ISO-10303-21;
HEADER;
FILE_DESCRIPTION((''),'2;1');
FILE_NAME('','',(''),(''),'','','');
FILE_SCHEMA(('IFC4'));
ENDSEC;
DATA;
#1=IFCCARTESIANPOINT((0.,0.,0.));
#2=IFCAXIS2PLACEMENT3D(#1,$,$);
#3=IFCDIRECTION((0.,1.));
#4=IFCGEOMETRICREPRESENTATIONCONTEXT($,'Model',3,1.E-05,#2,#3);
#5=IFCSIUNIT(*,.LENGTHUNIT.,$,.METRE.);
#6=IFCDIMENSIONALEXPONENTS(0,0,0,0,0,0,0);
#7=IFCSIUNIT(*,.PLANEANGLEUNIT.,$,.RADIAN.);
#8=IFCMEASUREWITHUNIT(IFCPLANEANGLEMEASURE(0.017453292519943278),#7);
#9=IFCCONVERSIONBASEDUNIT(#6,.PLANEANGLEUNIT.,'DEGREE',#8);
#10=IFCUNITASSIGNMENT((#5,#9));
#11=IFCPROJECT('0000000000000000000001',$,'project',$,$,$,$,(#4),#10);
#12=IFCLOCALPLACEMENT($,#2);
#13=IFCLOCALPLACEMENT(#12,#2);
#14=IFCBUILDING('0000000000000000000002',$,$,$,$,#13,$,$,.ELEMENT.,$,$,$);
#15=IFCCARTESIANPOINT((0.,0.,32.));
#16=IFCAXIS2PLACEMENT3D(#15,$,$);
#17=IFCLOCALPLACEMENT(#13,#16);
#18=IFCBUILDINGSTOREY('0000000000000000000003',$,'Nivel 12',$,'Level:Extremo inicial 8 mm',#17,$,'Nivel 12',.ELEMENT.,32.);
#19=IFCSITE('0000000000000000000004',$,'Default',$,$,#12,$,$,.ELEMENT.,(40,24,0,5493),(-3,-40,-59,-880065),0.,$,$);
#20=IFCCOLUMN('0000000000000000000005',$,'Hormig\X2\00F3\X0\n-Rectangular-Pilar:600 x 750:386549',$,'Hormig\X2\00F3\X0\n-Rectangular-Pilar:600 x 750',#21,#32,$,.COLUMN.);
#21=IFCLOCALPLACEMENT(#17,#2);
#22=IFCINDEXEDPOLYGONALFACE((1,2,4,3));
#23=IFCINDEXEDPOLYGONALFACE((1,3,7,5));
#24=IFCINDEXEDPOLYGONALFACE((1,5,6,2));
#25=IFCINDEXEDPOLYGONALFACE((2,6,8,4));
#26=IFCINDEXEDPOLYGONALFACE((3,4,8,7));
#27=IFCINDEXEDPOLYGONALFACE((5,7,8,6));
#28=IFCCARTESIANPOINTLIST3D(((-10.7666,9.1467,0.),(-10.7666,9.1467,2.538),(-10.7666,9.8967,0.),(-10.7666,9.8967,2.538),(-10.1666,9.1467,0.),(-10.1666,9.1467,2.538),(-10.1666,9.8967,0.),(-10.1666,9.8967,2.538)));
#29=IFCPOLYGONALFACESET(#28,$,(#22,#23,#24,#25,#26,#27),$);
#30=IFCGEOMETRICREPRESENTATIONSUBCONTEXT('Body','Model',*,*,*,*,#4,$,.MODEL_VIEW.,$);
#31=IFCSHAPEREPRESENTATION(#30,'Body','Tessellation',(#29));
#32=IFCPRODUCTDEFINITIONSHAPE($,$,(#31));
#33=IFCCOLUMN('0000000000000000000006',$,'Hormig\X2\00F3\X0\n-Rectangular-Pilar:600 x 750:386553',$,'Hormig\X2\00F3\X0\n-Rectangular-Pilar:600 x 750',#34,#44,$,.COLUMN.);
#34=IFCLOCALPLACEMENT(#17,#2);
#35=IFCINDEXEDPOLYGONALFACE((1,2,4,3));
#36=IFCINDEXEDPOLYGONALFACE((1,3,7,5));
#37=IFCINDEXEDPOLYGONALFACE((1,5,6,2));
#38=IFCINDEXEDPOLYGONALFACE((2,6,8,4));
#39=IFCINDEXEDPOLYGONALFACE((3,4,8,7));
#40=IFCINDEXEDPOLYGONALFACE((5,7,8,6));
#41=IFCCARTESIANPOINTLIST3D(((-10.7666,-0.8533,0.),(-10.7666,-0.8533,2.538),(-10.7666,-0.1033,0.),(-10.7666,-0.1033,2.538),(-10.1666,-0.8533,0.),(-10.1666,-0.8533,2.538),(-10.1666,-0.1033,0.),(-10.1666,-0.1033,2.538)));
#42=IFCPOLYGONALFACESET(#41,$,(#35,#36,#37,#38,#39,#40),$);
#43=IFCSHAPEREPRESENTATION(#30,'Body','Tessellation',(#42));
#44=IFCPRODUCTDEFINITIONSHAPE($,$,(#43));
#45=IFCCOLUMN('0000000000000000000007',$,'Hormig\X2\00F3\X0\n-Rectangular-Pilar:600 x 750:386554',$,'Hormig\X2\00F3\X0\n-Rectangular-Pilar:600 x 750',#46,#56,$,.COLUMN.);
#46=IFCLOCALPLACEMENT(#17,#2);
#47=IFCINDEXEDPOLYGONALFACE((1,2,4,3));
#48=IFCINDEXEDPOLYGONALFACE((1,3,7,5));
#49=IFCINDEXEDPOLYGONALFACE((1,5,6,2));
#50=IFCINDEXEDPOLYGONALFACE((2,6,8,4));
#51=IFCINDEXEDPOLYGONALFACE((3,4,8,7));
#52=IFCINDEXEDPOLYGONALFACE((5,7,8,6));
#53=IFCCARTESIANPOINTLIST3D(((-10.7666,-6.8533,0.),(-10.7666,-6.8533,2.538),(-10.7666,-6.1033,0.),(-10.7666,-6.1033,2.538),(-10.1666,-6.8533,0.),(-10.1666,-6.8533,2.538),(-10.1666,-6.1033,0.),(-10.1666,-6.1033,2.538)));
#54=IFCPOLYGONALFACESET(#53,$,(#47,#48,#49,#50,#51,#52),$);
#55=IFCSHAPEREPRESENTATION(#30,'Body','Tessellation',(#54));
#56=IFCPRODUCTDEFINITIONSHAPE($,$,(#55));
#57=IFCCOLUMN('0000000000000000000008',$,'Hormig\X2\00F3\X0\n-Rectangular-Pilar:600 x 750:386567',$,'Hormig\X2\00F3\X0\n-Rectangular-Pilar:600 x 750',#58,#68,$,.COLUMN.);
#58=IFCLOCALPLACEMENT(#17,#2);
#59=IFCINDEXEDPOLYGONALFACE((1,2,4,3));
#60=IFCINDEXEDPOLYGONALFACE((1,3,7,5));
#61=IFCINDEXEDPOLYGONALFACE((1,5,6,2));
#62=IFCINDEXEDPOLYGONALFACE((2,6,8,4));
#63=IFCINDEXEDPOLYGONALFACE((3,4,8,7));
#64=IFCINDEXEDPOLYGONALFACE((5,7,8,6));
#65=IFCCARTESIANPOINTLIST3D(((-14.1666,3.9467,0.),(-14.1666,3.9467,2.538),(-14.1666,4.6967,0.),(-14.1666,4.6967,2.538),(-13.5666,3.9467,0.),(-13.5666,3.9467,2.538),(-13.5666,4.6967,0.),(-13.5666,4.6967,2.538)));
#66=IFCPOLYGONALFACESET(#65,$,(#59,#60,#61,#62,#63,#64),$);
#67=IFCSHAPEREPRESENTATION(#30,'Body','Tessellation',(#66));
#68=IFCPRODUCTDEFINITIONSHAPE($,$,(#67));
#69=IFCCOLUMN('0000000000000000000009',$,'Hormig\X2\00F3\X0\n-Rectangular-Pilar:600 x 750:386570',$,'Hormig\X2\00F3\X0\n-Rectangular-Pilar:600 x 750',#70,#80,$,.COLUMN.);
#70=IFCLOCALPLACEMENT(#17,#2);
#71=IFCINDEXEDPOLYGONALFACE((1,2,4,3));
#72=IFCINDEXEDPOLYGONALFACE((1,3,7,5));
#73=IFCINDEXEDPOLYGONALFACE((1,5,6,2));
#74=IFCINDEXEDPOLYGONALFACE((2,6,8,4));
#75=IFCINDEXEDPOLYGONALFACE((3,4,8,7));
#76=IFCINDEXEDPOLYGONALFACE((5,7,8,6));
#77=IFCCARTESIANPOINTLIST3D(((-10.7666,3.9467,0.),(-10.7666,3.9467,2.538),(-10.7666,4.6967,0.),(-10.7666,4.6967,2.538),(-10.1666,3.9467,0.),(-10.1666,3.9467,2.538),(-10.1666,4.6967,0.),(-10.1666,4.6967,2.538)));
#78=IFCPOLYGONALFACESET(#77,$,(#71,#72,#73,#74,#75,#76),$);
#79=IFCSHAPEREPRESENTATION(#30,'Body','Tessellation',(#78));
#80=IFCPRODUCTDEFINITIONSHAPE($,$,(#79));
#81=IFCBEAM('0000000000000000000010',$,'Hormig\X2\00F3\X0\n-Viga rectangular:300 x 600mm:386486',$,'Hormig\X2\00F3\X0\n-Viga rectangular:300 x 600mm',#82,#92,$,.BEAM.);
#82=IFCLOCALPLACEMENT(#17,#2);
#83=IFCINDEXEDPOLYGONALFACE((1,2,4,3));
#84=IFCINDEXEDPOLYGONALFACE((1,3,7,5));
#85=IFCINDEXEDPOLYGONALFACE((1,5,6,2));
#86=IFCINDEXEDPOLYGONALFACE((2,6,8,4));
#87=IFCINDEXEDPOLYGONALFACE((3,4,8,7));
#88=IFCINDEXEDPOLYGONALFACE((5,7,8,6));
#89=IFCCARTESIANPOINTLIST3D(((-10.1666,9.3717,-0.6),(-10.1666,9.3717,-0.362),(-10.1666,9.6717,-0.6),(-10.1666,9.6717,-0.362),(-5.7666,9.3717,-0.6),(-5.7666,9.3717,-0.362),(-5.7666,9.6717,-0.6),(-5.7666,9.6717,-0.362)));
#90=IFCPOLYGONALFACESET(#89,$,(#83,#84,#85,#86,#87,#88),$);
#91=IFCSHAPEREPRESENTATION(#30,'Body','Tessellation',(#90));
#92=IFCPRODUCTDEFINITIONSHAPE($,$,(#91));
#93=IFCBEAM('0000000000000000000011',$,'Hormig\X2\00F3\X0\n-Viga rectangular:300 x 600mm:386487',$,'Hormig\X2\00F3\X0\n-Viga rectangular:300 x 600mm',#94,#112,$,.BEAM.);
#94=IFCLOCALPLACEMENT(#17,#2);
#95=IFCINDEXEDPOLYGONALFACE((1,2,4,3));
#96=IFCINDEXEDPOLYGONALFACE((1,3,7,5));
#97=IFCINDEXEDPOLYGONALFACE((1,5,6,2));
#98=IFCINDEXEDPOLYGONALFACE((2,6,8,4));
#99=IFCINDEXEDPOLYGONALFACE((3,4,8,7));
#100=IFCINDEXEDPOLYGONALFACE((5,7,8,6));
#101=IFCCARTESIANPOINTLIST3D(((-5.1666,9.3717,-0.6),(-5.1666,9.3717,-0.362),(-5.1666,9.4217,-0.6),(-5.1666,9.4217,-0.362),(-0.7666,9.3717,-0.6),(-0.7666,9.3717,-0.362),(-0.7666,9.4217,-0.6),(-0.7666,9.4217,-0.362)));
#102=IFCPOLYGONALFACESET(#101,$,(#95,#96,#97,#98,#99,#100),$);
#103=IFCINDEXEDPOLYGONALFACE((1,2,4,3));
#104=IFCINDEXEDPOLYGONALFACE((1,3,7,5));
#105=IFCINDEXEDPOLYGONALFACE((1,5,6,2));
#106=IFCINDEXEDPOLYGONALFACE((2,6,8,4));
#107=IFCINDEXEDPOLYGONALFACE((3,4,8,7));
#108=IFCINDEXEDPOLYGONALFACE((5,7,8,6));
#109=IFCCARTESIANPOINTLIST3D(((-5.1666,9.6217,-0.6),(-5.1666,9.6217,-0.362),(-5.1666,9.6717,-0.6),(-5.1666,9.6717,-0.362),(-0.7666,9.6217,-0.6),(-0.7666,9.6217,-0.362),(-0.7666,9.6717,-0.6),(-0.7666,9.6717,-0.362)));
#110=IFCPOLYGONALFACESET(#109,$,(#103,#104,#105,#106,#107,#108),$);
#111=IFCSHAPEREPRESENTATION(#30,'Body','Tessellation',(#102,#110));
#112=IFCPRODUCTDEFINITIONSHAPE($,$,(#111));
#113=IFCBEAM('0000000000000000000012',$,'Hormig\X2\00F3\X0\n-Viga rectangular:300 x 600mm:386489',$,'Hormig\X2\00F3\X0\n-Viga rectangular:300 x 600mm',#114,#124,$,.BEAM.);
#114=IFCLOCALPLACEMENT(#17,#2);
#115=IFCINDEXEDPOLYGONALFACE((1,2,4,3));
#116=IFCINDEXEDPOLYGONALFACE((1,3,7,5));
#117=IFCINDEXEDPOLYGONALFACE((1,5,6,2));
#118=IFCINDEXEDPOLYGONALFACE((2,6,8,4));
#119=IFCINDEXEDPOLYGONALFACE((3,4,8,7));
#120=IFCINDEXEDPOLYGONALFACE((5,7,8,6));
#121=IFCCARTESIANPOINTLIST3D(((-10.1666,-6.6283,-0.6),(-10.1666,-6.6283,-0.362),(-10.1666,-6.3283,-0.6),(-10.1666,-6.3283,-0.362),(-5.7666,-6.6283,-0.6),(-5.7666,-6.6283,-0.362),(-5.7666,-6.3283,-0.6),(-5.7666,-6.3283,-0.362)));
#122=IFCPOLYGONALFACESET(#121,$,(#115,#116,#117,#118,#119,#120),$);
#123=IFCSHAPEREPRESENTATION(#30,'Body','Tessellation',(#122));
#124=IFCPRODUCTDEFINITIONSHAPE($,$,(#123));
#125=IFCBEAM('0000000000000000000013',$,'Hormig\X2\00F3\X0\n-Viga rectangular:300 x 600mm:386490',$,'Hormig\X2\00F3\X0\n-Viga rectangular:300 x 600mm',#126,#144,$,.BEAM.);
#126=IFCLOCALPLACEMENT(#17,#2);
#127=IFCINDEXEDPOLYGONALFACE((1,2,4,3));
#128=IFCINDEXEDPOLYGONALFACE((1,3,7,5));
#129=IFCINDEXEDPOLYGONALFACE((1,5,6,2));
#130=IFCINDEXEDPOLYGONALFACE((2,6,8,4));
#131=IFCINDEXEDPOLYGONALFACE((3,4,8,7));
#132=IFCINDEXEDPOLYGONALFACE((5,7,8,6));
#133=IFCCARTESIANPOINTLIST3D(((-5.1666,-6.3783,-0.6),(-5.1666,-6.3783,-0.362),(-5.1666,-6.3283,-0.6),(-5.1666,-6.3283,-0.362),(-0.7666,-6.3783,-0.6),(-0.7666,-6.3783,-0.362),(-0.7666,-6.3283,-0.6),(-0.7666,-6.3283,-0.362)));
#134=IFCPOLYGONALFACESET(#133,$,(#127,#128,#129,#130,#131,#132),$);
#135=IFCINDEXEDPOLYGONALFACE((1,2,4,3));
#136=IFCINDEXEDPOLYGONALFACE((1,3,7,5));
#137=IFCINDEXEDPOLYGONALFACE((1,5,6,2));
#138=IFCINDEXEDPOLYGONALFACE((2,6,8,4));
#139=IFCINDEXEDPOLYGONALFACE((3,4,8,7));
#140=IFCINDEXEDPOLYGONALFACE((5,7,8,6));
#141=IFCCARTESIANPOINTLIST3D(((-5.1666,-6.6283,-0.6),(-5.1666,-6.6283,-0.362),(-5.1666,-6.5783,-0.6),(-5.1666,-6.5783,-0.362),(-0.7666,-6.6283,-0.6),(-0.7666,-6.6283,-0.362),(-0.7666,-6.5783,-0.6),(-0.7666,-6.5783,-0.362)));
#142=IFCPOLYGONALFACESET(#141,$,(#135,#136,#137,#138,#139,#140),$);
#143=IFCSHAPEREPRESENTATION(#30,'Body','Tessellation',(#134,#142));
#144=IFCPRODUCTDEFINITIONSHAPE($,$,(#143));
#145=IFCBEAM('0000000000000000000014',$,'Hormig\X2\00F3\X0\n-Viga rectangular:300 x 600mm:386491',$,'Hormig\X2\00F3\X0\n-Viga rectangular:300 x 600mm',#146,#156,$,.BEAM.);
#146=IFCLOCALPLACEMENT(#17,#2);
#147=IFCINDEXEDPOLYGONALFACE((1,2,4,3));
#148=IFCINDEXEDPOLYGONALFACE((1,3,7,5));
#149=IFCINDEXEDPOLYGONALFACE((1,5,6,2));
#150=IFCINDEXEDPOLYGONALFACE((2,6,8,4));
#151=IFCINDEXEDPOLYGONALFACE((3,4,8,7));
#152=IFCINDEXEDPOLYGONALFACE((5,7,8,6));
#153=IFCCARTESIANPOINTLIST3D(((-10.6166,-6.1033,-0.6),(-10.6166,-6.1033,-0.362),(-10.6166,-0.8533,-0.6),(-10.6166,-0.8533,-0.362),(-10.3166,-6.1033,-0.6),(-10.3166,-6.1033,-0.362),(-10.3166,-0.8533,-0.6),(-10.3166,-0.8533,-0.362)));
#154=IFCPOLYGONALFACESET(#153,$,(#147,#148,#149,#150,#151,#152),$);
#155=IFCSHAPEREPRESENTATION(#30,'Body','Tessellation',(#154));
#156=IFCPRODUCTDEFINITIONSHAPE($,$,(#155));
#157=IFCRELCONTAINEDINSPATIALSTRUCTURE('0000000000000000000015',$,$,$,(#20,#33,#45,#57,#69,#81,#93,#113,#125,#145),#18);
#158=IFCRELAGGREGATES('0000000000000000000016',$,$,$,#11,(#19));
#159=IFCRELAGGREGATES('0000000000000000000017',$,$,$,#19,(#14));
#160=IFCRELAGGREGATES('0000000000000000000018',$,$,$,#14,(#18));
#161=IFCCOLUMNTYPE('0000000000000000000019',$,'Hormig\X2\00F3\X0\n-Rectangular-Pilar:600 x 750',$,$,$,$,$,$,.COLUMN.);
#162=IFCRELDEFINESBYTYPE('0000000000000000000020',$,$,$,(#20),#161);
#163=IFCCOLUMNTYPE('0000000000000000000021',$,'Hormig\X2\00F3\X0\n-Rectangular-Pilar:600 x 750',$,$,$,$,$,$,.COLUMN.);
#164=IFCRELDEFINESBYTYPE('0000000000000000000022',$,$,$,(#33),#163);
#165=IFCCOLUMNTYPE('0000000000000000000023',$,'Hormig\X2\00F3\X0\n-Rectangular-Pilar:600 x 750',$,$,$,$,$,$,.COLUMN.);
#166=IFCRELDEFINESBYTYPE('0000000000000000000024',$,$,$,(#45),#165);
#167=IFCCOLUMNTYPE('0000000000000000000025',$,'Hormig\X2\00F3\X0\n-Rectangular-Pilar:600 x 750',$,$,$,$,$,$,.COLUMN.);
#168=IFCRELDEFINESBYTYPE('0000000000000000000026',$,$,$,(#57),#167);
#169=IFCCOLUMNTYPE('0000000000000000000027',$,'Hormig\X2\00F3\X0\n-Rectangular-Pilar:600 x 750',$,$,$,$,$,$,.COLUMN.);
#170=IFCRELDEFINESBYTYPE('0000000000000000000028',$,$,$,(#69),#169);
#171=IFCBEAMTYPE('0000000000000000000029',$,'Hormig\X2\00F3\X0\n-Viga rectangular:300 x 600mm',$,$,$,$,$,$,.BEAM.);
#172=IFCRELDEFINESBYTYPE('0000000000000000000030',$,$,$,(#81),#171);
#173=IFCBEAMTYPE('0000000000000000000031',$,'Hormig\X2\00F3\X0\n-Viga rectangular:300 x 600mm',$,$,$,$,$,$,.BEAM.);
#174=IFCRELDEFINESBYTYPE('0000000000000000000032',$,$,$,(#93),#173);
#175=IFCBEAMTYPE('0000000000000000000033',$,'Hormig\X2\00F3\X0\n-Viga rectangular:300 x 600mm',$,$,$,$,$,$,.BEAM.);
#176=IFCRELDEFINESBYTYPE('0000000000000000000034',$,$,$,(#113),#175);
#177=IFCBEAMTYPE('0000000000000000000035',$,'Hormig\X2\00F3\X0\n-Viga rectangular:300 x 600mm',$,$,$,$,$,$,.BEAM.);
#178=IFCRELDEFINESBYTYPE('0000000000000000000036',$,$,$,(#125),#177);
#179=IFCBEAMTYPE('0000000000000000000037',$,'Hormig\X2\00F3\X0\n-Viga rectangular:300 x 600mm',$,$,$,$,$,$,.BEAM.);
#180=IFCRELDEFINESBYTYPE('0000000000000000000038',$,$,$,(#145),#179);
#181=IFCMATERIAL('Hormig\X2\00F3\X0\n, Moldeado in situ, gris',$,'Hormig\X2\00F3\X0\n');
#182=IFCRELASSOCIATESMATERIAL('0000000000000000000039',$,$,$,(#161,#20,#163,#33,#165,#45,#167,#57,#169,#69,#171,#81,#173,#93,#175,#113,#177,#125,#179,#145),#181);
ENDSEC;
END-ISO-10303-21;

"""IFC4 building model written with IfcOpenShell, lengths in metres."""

from ifc_helpers import new_model, entity, si_unit, converted_unit, direction, frame, origin, place, context, subcontext, project, spatial, indexed_curve, outline, extrude, source, transform, mapped, material, type_object, type_shapes, element, save


model = new_model("IFC4")

# Units and contexts
model_context = context("Model", 3, precision=1e-05, world=origin(), true_north=direction((0.0, 1.0)))
body_context = subcontext(model_context, "Body", "Model", "MODEL_VIEW")
ifc_project = project(units=[si_unit("LENGTHUNIT", "METRE"), converted_unit("PLANEANGLEUNIT", "DEGREE", entity("IfcPlaneAngleMeasure", 0.017453292519943278), si_unit("PLANEANGLEUNIT", "RADIAN"), dimensions=[0, 0, 0, 0, 0, 0, 0])], contexts=[model_context])

# Site, building, storey
site_placement = place(None, origin())
site = spatial("IfcSite", under=ifc_project, at=site_placement, Name="Default", CompositionType="ELEMENT", RefLatitude=(40, 24, 0, 5493), RefLongitude=(-3, -40, -59, -880065), RefElevation=0.0)
building_placement = place(site_placement, origin())
building = spatial("IfcBuilding", under=site, at=building_placement, CompositionType="ELEMENT")
storey_placement = place(building_placement, frame((0.0, 0.0, 32.0)))
storey = spatial("IfcBuildingStorey", under=building, at=storey_placement, Name="Nivel 12", ObjectType="Level:Extremo inicial 8 mm", LongName="Nivel 12", CompositionType="ELEMENT", Elevation=32.0)

# Columns
ifc_material_1 = material(Name="Hormigón, Moldeado in situ, gris", Category="Hormigón")
column_type_1 = type_object("IfcColumnType", Name="Hormigón-Rectangular-Pilar:600 x 750", PredefinedType="COLUMN", material=ifc_material_1)
shared_shape_1 = source(origin(), body_context, "Body", "SweptSolid", [
    extrude(outline(indexed_curve([(-0.3, -0.375), (0.3, -0.375), (0.3, 0.375), (-0.3, 0.375), (-0.3, -0.375)], self_intersect=False)), frame((-10.4666, 9.5217, 32.0), z_axis=(0.0, 0.0, 1.0), x_axis=(-1.0, 0.0, 0.0)), (0.0, 0.0, 1.0), 2.538),
])
type_shapes(column_type_1, [shared_shape_1])
column_1_placement = place(storey_placement, frame((0.0, 0.0, -32.0)))
element("IfcColumn", 1, at=column_1_placement, inside=storey, type_object=column_type_1, material=ifc_material_1, Name="Hormigón-Rectangular-Pilar:600 x 750:386549", ObjectType="Hormigón-Rectangular-Pilar:600 x 750", PredefinedType="COLUMN", context=body_context, shape_type="MappedRepresentation", body=[
    mapped(shared_shape_1, transform((0.0, 0.0, 0.0), scale=1.0)),
])
column_type_2 = type_object("IfcColumnType", Name="Hormigón-Rectangular-Pilar:600 x 750", PredefinedType="COLUMN", material=ifc_material_1)
shared_shape_2 = source(origin(), body_context, "Body", "SweptSolid", [
    extrude(outline(indexed_curve([(-0.3, -0.375), (0.3, -0.375), (0.3, 0.375), (-0.3, 0.375), (-0.3, -0.375)], self_intersect=False)), frame((-10.4666, -0.4783, 32.0), z_axis=(0.0, 0.0, 1.0), x_axis=(-1.0, 0.0, 0.0)), (0.0, 0.0, 1.0), 2.538),
])
type_shapes(column_type_2, [shared_shape_2])
column_2_placement = place(storey_placement, frame((0.0, 0.0, -32.0)))
element("IfcColumn", 2, at=column_2_placement, inside=storey, type_object=column_type_2, material=ifc_material_1, Name="Hormigón-Rectangular-Pilar:600 x 750:386553", ObjectType="Hormigón-Rectangular-Pilar:600 x 750", PredefinedType="COLUMN", context=body_context, shape_type="MappedRepresentation", body=[
    mapped(shared_shape_2, transform((0.0, 0.0, 0.0), scale=1.0)),
])
column_type_3 = type_object("IfcColumnType", Name="Hormigón-Rectangular-Pilar:600 x 750", PredefinedType="COLUMN", material=ifc_material_1)
shared_shape_3 = source(origin(), body_context, "Body", "SweptSolid", [
    extrude(outline(indexed_curve([(-0.3, -0.375), (0.3, -0.375), (0.3, 0.375), (-0.3, 0.375), (-0.3, -0.375)], self_intersect=False)), frame((-10.4666, -6.4783, 32.0), z_axis=(0.0, 0.0, 1.0), x_axis=(-1.0, 0.0, 0.0)), (0.0, 0.0, 1.0), 2.538),
])
type_shapes(column_type_3, [shared_shape_3])
column_3_placement = place(storey_placement, frame((0.0, 0.0, -32.0)))
element("IfcColumn", 3, at=column_3_placement, inside=storey, type_object=column_type_3, material=ifc_material_1, Name="Hormigón-Rectangular-Pilar:600 x 750:386554", ObjectType="Hormigón-Rectangular-Pilar:600 x 750", PredefinedType="COLUMN", context=body_context, shape_type="MappedRepresentation", body=[
    mapped(shared_shape_3, transform((0.0, 0.0, 0.0), scale=1.0)),
])
column_type_4 = type_object("IfcColumnType", Name="Hormigón-Rectangular-Pilar:600 x 750", PredefinedType="COLUMN", material=ifc_material_1)
shared_shape_4 = source(origin(), body_context, "Body", "SweptSolid", [
    extrude(outline(indexed_curve([(-0.3, -0.375), (0.3, -0.375), (0.3, 0.375), (-0.3, 0.375), (-0.3, -0.375)], self_intersect=False)), frame((-13.8666, 4.3217, 32.0), z_axis=(0.0, 0.0, 1.0), x_axis=(-1.0, 0.0, 0.0)), (0.0, 0.0, 1.0), 2.538),
])
type_shapes(column_type_4, [shared_shape_4])
column_4_placement = place(storey_placement, frame((0.0, 0.0, -32.0)))
element("IfcColumn", 4, at=column_4_placement, inside=storey, type_object=column_type_4, material=ifc_material_1, Name="Hormigón-Rectangular-Pilar:600 x 750:386567", ObjectType="Hormigón-Rectangular-Pilar:600 x 750", PredefinedType="COLUMN", context=body_context, shape_type="MappedRepresentation", body=[
    mapped(shared_shape_4, transform((0.0, 0.0, 0.0), scale=1.0)),
])
column_type_5 = type_object("IfcColumnType", Name="Hormigón-Rectangular-Pilar:600 x 750", PredefinedType="COLUMN", material=ifc_material_1)
shared_shape_5 = source(origin(), body_context, "Body", "SweptSolid", [
    extrude(outline(indexed_curve([(-0.3, -0.375), (0.3, -0.375), (0.3, 0.375), (-0.3, 0.375), (-0.3, -0.375)], self_intersect=False)), frame((-10.4666, 4.3217, 32.0), z_axis=(0.0, 0.0, 1.0), x_axis=(-1.0, 0.0, 0.0)), (0.0, 0.0, 1.0), 2.538),
])
type_shapes(column_type_5, [shared_shape_5])
column_5_placement = place(storey_placement, frame((0.0, 0.0, -32.0)))
element("IfcColumn", 5, at=column_5_placement, inside=storey, type_object=column_type_5, material=ifc_material_1, Name="Hormigón-Rectangular-Pilar:600 x 750:386570", ObjectType="Hormigón-Rectangular-Pilar:600 x 750", PredefinedType="COLUMN", context=body_context, shape_type="MappedRepresentation", body=[
    mapped(shared_shape_5, transform((0.0, 0.0, 0.0), scale=1.0)),
])

# Beams
beam_type_1 = type_object("IfcBeamType", Name="Hormigón-Viga rectangular:300 x 600mm", PredefinedType="BEAM", material=ifc_material_1)
shared_shape_6 = source(origin(), body_context, "Body", "SweptSolid", [
    extrude(outline(indexed_curve([(-0.119, -0.15), (0.119, -0.15), (0.119, 0.15), (-0.119, 0.15), (-0.119, -0.15)], self_intersect=False)), frame((-5.7666, 9.5217, 31.519), z_axis=(-1.0, 0.0, 0.0), x_axis=(0.0, 0.0, -1.0)), (0.0, 0.0, 1.0), 4.4),
])
type_shapes(beam_type_1, [shared_shape_6])
beam_1_placement = place(storey_placement, frame((0.0, 0.0, -32.0)))
element("IfcBeam", 6, at=beam_1_placement, inside=storey, type_object=beam_type_1, material=ifc_material_1, Name="Hormigón-Viga rectangular:300 x 600mm:386486", ObjectType="Hormigón-Viga rectangular:300 x 600mm", PredefinedType="BEAM", context=body_context, shape_type="MappedRepresentation", body=[
    mapped(shared_shape_6, transform((0.0, 0.0, 0.0), scale=1.0)),
])
beam_type_2 = type_object("IfcBeamType", Name="Hormigón-Viga rectangular:300 x 600mm", PredefinedType="BEAM", material=ifc_material_1)
shared_shape_7 = source(origin(), body_context, "Body", "SweptSolid", [
    extrude(outline(indexed_curve([(-0.119, -0.025), (0.119, -0.025), (0.119, 0.025), (-0.119, 0.025), (-0.119, -0.025)], self_intersect=False)), frame((-5.1666, 9.3967, 31.519), z_axis=(1.0, 0.0, 0.0), x_axis=(0.0, 0.0, -1.0)), (0.0, 0.0, 1.0), 4.4),
    extrude(outline(indexed_curve([(-0.119, -0.025), (0.119, -0.025), (0.119, 0.025), (-0.119, 0.025), (-0.119, -0.025)], self_intersect=False)), frame((-5.1666, 9.6467, 31.519), z_axis=(1.0, 0.0, 0.0), x_axis=(0.0, 0.0, -1.0)), (0.0, 0.0, 1.0), 4.4),
])
type_shapes(beam_type_2, [shared_shape_7])
beam_2_placement = place(storey_placement, frame((0.0, 0.0, -32.0)))
element("IfcBeam", 7, at=beam_2_placement, inside=storey, type_object=beam_type_2, material=ifc_material_1, Name="Hormigón-Viga rectangular:300 x 600mm:386487", ObjectType="Hormigón-Viga rectangular:300 x 600mm", PredefinedType="BEAM", context=body_context, shape_type="MappedRepresentation", body=[
    mapped(shared_shape_7, transform((0.0, 0.0, 0.0), scale=1.0)),
])
beam_type_3 = type_object("IfcBeamType", Name="Hormigón-Viga rectangular:300 x 600mm", PredefinedType="BEAM", material=ifc_material_1)
shared_shape_8 = source(origin(), body_context, "Body", "SweptSolid", [
    extrude(outline(indexed_curve([(-0.119, -0.15), (0.119, -0.15), (0.119, 0.15), (-0.119, 0.15), (-0.119, -0.15)], self_intersect=False)), frame((-10.1666, -6.4783, 31.519), z_axis=(1.0, 0.0, 0.0), x_axis=(0.0, 0.0, -1.0)), (0.0, 0.0, 1.0), 4.4),
])
type_shapes(beam_type_3, [shared_shape_8])
beam_3_placement = place(storey_placement, frame((0.0, 0.0, -32.0)))
element("IfcBeam", 8, at=beam_3_placement, inside=storey, type_object=beam_type_3, material=ifc_material_1, Name="Hormigón-Viga rectangular:300 x 600mm:386489", ObjectType="Hormigón-Viga rectangular:300 x 600mm", PredefinedType="BEAM", context=body_context, shape_type="MappedRepresentation", body=[
    mapped(shared_shape_8, transform((0.0, 0.0, 0.0), scale=1.0)),
])
beam_type_4 = type_object("IfcBeamType", Name="Hormigón-Viga rectangular:300 x 600mm", PredefinedType="BEAM", material=ifc_material_1)
shared_shape_9 = source(origin(), body_context, "Body", "SweptSolid", [
    extrude(outline(indexed_curve([(-0.119, -0.025), (0.119, -0.025), (0.119, 0.025), (-0.119, 0.025), (-0.119, -0.025)], self_intersect=False)), frame((-0.7666, -6.3533, 31.519), z_axis=(-1.0, 0.0, 0.0), x_axis=(0.0, 0.0, -1.0)), (0.0, 0.0, 1.0), 4.4),
    extrude(outline(indexed_curve([(-0.119, -0.025), (0.119, -0.025), (0.119, 0.025), (-0.119, 0.025), (-0.119, -0.025)], self_intersect=False)), frame((-0.7666, -6.6033, 31.519), z_axis=(-1.0, 0.0, 0.0), x_axis=(0.0, 0.0, -1.0)), (0.0, 0.0, 1.0), 4.4),
])
type_shapes(beam_type_4, [shared_shape_9])
beam_4_placement = place(storey_placement, frame((0.0, 0.0, -32.0)))
element("IfcBeam", 9, at=beam_4_placement, inside=storey, type_object=beam_type_4, material=ifc_material_1, Name="Hormigón-Viga rectangular:300 x 600mm:386490", ObjectType="Hormigón-Viga rectangular:300 x 600mm", PredefinedType="BEAM", context=body_context, shape_type="MappedRepresentation", body=[
    mapped(shared_shape_9, transform((0.0, 0.0, 0.0), scale=1.0)),
])
beam_type_5 = type_object("IfcBeamType", Name="Hormigón-Viga rectangular:300 x 600mm", PredefinedType="BEAM", material=ifc_material_1)
shared_shape_10 = source(origin(), body_context, "Body", "SweptSolid", [
    extrude(outline(indexed_curve([(-0.15, -0.119), (0.15, -0.119), (0.15, 0.119), (-0.15, 0.119), (-0.15, -0.119)], self_intersect=False)), frame((-10.4666, -6.1033, 31.519), z_axis=(0.0, 1.0, 0.0), x_axis=(-1.0, 0.0, 0.0)), (0.0, 0.0, 1.0), 5.25),
])
type_shapes(beam_type_5, [shared_shape_10])
beam_5_placement = place(storey_placement, frame((0.0, 0.0, -32.0)))
element("IfcBeam", 10, at=beam_5_placement, inside=storey, type_object=beam_type_5, material=ifc_material_1, Name="Hormigón-Viga rectangular:300 x 600mm:386491", ObjectType="Hormigón-Viga rectangular:300 x 600mm", PredefinedType="BEAM", context=body_context, shape_type="MappedRepresentation", body=[
    mapped(shared_shape_10, transform((0.0, 0.0, 0.0), scale=1.0)),
])

save(model, "model.ifc")
